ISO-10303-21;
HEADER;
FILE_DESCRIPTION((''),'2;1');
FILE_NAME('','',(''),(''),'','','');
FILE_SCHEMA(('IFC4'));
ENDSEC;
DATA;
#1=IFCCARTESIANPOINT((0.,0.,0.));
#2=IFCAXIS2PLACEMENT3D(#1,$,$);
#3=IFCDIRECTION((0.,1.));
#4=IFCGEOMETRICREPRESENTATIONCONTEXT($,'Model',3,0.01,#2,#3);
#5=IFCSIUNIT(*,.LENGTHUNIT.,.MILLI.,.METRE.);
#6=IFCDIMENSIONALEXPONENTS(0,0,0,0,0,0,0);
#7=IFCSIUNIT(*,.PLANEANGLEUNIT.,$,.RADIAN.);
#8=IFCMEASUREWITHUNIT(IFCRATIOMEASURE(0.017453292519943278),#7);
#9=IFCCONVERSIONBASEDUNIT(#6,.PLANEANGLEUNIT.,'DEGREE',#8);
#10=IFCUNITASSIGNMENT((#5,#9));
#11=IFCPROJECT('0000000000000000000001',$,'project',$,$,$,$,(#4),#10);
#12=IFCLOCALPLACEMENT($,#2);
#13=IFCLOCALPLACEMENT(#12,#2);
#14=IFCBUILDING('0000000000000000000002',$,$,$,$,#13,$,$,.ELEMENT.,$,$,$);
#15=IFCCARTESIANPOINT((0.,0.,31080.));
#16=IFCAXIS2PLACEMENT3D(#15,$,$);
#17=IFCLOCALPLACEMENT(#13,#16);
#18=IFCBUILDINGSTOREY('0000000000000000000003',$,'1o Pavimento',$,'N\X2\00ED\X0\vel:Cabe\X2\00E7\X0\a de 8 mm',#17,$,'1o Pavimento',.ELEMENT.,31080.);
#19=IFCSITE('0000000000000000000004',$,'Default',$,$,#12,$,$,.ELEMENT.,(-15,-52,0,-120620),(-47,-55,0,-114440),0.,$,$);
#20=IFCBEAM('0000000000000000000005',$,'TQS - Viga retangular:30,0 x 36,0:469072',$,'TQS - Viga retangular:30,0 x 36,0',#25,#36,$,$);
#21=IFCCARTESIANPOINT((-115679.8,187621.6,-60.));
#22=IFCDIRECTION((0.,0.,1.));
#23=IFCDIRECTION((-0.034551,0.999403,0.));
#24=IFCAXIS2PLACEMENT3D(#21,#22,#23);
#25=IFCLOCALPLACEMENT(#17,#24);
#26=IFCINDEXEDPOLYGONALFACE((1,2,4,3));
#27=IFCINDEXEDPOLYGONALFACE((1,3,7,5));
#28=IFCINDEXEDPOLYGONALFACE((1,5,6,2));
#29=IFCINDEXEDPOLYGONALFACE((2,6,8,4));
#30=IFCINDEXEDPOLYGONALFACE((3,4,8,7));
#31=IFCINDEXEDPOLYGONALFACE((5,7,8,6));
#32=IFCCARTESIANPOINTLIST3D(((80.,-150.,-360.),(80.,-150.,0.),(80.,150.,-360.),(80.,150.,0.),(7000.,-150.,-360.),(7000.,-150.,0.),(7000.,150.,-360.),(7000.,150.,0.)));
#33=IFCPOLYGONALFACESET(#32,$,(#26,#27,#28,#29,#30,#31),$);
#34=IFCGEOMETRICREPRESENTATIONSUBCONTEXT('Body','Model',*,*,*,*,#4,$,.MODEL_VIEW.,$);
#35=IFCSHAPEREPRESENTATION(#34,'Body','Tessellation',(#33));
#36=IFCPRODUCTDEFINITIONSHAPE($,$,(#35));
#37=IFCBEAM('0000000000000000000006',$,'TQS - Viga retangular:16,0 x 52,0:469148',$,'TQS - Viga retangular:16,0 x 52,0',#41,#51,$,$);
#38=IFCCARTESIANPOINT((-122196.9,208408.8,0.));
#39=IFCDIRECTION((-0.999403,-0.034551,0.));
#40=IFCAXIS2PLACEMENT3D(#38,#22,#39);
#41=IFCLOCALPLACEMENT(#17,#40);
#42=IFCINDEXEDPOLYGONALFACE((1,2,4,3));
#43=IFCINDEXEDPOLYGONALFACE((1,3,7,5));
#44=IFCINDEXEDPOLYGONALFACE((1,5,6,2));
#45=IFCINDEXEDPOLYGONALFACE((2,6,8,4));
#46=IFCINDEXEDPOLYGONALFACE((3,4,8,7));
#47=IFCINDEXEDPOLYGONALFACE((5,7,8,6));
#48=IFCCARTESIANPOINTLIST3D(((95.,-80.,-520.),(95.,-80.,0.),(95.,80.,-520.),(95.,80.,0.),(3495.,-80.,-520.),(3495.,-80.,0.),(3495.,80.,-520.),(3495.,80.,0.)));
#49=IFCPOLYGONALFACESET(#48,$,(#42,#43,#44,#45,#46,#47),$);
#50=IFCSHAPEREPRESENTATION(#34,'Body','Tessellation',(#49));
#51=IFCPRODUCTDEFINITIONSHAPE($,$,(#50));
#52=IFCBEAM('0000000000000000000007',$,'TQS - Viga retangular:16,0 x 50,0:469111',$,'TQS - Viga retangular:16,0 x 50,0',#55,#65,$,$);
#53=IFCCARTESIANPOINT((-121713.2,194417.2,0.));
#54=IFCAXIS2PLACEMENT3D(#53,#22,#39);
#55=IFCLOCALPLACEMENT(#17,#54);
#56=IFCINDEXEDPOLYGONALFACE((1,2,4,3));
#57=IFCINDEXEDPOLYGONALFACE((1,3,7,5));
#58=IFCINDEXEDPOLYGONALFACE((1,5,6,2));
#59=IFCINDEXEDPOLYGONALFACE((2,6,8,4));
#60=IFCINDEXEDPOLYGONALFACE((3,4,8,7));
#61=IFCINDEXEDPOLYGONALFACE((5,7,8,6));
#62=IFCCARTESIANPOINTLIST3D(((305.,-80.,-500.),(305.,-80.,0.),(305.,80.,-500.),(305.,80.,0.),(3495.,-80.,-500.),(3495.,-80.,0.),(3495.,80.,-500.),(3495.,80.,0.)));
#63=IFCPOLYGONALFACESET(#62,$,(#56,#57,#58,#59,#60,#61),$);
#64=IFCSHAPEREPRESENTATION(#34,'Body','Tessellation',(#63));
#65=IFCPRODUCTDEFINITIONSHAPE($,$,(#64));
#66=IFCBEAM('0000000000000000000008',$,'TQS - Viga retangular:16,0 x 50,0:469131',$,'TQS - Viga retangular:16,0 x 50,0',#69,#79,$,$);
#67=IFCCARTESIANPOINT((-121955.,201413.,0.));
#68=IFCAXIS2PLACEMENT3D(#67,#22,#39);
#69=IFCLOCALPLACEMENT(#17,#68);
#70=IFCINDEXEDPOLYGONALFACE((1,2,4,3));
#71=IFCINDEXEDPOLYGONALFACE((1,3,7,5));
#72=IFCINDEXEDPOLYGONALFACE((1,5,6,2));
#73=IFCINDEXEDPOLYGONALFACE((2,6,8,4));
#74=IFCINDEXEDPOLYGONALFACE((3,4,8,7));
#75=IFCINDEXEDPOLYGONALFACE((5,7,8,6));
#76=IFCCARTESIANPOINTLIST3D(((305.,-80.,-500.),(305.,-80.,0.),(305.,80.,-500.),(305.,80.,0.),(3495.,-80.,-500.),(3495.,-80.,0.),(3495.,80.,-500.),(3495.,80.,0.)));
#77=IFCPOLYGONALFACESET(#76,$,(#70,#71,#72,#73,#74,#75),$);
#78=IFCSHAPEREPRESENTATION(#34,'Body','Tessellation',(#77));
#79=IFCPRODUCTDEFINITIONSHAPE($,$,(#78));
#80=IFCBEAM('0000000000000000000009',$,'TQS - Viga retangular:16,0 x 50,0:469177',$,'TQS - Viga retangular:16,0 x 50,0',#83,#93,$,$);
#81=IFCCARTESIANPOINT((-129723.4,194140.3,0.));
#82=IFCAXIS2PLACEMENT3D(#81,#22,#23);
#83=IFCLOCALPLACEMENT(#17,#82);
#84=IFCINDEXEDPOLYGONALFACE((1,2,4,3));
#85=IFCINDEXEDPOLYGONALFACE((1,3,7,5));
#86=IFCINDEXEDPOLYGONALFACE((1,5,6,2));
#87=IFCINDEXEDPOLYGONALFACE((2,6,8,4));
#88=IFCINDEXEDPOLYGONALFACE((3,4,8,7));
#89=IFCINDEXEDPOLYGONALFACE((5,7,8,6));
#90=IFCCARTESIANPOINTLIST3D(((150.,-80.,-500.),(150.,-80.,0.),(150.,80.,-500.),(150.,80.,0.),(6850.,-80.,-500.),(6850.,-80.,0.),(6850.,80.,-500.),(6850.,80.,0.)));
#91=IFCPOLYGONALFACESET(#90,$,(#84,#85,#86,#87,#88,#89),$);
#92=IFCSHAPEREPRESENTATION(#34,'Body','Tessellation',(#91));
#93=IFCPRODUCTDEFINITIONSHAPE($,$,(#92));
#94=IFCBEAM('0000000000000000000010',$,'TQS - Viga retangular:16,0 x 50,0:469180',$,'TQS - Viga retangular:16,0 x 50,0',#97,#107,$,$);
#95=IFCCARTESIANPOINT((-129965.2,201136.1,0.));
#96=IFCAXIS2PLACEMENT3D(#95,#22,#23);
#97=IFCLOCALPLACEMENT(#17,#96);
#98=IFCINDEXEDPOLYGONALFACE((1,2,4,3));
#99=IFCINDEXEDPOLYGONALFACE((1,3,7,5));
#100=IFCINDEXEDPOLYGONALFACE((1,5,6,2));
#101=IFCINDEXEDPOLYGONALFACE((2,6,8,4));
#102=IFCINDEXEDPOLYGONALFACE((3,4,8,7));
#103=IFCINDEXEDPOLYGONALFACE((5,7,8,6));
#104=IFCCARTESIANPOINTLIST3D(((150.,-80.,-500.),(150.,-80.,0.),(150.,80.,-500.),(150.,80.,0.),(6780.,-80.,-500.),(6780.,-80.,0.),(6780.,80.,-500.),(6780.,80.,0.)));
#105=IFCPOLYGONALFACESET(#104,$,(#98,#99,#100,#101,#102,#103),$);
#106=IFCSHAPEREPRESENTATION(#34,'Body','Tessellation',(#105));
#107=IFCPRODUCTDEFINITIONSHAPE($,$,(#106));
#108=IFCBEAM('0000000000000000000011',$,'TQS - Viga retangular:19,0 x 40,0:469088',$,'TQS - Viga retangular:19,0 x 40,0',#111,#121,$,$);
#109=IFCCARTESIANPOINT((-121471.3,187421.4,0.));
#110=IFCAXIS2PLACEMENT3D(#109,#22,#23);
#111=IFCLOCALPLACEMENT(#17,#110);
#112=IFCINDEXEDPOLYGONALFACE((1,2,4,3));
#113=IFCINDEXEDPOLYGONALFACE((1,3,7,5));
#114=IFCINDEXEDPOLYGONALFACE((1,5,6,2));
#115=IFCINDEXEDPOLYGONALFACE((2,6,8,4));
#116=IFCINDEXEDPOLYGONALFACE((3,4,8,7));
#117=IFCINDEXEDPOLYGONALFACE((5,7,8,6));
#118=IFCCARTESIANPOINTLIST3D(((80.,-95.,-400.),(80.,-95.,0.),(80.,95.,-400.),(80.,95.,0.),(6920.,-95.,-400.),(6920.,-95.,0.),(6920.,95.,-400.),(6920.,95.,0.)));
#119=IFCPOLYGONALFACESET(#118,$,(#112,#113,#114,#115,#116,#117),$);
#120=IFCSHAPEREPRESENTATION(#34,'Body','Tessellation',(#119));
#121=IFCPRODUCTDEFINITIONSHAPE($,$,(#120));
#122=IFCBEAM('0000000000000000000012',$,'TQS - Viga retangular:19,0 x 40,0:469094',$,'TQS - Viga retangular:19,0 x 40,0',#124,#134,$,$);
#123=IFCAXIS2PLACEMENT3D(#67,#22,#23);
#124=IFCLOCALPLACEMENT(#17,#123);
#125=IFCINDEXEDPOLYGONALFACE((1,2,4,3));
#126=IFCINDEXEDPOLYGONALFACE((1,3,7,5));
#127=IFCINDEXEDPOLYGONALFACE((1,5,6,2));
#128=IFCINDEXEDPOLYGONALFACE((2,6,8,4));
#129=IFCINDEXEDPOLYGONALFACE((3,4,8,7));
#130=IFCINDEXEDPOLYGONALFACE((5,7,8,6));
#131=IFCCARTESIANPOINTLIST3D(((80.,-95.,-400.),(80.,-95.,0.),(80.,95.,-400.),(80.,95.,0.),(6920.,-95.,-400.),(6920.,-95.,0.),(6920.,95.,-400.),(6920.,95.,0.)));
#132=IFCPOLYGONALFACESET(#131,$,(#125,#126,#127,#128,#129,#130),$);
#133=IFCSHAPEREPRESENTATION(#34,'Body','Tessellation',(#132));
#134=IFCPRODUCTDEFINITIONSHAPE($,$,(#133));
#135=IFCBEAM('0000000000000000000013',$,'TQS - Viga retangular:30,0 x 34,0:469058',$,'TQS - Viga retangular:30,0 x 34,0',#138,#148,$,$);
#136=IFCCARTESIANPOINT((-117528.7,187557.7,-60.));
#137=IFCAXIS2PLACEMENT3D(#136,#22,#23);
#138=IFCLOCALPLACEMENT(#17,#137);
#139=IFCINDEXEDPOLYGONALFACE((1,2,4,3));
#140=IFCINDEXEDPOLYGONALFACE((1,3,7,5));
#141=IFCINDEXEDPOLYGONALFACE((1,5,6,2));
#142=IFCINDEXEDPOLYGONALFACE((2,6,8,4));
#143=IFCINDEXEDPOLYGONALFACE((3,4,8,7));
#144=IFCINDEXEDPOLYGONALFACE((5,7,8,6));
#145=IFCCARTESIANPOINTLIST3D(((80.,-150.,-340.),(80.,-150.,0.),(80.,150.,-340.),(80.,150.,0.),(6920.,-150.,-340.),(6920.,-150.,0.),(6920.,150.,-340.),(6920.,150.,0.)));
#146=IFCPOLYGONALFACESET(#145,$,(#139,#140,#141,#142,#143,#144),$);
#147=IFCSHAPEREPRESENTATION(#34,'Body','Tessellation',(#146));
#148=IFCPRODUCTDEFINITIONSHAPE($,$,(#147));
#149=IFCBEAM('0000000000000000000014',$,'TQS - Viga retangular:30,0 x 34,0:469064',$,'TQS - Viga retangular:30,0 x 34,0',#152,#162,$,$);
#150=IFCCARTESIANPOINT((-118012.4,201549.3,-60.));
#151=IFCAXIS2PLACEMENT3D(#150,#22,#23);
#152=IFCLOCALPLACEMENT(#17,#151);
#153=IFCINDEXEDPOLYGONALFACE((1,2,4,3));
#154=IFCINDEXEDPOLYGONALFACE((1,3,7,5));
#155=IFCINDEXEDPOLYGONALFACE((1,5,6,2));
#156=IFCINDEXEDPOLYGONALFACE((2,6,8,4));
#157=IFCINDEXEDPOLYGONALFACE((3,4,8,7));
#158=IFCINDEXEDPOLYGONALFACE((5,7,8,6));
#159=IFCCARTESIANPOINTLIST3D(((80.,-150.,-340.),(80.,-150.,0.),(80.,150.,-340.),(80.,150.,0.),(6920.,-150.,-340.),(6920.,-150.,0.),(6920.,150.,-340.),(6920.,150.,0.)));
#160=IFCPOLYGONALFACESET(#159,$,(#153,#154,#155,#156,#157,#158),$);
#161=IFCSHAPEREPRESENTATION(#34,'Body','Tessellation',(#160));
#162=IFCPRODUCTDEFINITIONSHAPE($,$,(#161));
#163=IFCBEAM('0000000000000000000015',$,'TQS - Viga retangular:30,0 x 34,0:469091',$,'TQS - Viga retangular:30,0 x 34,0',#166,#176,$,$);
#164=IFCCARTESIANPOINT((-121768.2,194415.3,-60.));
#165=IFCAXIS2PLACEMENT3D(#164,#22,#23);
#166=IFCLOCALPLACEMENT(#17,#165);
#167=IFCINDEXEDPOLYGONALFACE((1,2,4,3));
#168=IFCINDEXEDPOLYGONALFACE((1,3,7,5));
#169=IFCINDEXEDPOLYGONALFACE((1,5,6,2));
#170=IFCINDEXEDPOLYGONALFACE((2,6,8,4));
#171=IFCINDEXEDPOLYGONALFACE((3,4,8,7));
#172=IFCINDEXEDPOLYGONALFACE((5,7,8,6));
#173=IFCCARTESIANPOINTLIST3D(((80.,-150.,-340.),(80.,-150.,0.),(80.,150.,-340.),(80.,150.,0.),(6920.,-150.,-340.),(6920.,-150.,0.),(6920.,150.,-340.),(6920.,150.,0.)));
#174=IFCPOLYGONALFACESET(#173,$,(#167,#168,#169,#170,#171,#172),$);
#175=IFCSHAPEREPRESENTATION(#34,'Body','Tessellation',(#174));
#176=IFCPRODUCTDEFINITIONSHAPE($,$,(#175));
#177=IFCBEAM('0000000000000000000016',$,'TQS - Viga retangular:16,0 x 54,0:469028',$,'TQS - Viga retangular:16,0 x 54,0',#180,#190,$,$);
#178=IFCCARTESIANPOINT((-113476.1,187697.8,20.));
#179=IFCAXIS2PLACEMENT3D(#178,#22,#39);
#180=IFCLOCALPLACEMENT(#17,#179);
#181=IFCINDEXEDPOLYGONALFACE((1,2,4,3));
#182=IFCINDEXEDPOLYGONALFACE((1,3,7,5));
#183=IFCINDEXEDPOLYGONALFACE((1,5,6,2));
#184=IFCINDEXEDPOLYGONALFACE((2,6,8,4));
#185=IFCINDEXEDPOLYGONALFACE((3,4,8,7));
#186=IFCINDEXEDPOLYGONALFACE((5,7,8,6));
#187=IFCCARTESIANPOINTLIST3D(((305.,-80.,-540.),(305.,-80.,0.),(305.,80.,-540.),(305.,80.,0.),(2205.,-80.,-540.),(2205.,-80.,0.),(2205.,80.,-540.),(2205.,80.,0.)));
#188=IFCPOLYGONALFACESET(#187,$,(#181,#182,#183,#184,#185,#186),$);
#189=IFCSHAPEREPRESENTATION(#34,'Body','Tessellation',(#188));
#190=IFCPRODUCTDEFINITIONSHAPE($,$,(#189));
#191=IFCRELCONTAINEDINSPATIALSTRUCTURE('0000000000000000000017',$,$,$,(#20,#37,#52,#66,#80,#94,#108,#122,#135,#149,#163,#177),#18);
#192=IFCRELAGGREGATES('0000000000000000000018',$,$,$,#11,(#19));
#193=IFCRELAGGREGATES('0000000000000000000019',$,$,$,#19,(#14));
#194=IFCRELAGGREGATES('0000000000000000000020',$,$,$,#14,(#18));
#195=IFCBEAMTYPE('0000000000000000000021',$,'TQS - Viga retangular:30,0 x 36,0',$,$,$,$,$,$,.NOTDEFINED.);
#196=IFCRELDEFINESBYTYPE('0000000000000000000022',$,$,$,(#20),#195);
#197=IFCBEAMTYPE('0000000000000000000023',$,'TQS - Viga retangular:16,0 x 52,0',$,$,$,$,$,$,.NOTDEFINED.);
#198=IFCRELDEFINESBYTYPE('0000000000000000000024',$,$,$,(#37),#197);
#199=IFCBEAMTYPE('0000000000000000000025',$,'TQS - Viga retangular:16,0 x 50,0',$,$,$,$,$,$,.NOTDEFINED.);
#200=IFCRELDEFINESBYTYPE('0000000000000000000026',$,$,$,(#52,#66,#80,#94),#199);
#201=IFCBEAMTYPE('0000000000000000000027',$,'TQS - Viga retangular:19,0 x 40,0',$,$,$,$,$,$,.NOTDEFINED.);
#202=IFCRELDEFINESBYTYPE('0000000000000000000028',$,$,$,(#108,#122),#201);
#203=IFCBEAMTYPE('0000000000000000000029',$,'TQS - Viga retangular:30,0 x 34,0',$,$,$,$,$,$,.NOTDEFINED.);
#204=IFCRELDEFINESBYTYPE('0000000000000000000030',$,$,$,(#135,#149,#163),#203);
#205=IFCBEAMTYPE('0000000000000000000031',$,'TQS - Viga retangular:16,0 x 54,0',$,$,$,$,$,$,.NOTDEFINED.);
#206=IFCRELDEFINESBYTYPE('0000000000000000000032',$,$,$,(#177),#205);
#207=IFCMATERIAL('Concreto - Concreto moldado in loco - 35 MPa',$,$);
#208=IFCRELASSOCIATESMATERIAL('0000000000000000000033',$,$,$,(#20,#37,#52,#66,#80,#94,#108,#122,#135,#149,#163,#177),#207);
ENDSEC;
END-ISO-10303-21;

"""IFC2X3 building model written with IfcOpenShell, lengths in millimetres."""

from ifc_helpers import new_model, entity, si_unit, converted_unit, direction, frame, frame_2d, origin, place, context, subcontext, project, spatial, rectangle, extrude, material, type_object, element, save


model = new_model("IFC2X3")

# Units and contexts
model_context = context("Model", 3, precision=0.01, world=origin(), true_north=direction((0.0, 1.0)))
body_context = subcontext(model_context, "Body", "Model", "MODEL_VIEW")
ifc_project = project(units=[si_unit("LENGTHUNIT", "METRE", prefix="MILLI"), converted_unit("PLANEANGLEUNIT", "DEGREE", entity("IfcRatioMeasure", 0.017453292519943278), si_unit("PLANEANGLEUNIT", "RADIAN"), dimensions=[0, 0, 0, 0, 0, 0, 0])], contexts=[model_context])

# Site, building, storey
site_placement = place(None, origin())
site = spatial("IfcSite", under=ifc_project, at=site_placement, Name="Default", CompositionType="ELEMENT", RefLatitude=(-15, -52, 0, -120620), RefLongitude=(-47, -55, 0, -114440), RefElevation=0.0)
building_placement = place(site_placement, origin())
building = spatial("IfcBuilding", under=site, at=building_placement, CompositionType="ELEMENT")
storey_placement = place(building_placement, frame((0.0, 0.0, 31080.0)))
storey = spatial("IfcBuildingStorey", under=building, at=storey_placement, Name="1o Pavimento", ObjectType="Nível:Cabeça de 8 mm", LongName="1o Pavimento", CompositionType="ELEMENT", Elevation=31080.0)

# Beams
ifc_material_1 = material(Name="Concreto - Concreto moldado in loco - 35 MPa")
beam_type_1 = type_object("IfcBeamType", Name="TQS - Viga retangular:30,0 x 36,0", PredefinedType="NOTDEFINED")
beam_1_placement = place(storey_placement, frame((-115679.8, 187621.6, -60.0), z_axis=(0.0, 0.0, 1.0), x_axis=(-0.034551, 0.999403, 0.0)))
element("IfcBeam", 1, at=beam_1_placement, inside=storey, type_object=beam_type_1, material=ifc_material_1, Name="TQS - Viga retangular:30,0 x 36,0:469072", ObjectType="TQS - Viga retangular:30,0 x 36,0", context=body_context, shape_type="SweptSolid", body=[
    extrude(rectangle(XDim=360.0, YDim=300.0, at=frame_2d((0.0, 0.0), x_axis=(1.0, 0.0))), frame((80.0, 0.0, -180.0), z_axis=(1.0, 0.0, 0.0), x_axis=(0.0, 0.0, -1.0)), (0.0, 0.0, 1.0), 6920.0),
])
beam_type_2 = type_object("IfcBeamType", Name="TQS - Viga retangular:16,0 x 52,0", PredefinedType="NOTDEFINED")
beam_2_placement = place(storey_placement, frame((-122196.9, 208408.8, 0.0), z_axis=(0.0, 0.0, 1.0), x_axis=(-0.999403, -0.034551, 0.0)))
element("IfcBeam", 2, at=beam_2_placement, inside=storey, type_object=beam_type_2, material=ifc_material_1, Name="TQS - Viga retangular:16,0 x 52,0:469148", ObjectType="TQS - Viga retangular:16,0 x 52,0", context=body_context, shape_type="SweptSolid", body=[
    extrude(rectangle(XDim=520.0, YDim=160.0, at=frame_2d((0.0, 0.0), x_axis=(1.0, 0.0))), frame((95.0, 0.0, -260.0), z_axis=(1.0, 0.0, 0.0), x_axis=(0.0, 0.0, -1.0)), (0.0, 0.0, 1.0), 3400.0),
])
beam_type_3 = type_object("IfcBeamType", Name="TQS - Viga retangular:16,0 x 50,0", PredefinedType="NOTDEFINED")
beam_3_placement = place(storey_placement, frame((-121713.2, 194417.2, 0.0), z_axis=(0.0, 0.0, 1.0), x_axis=(-0.999403, -0.034551, 0.0)))
element("IfcBeam", 3, at=beam_3_placement, inside=storey, type_object=beam_type_3, material=ifc_material_1, Name="TQS - Viga retangular:16,0 x 50,0:469111", ObjectType="TQS - Viga retangular:16,0 x 50,0", context=body_context, shape_type="SweptSolid", body=[
    extrude(rectangle(XDim=500.0, YDim=160.0, at=frame_2d((0.0, 0.0), x_axis=(1.0, 0.0))), frame((305.0, 0.0, -250.0), z_axis=(1.0, 0.0, 0.0), x_axis=(0.0, 0.0, -1.0)), (0.0, 0.0, 1.0), 3190.0),
])
beam_4_placement = place(storey_placement, frame((-121955.0, 201413.0, 0.0), z_axis=(0.0, 0.0, 1.0), x_axis=(-0.999403, -0.034551, 0.0)))
element("IfcBeam", 4, at=beam_4_placement, inside=storey, type_object=beam_type_3, material=ifc_material_1, Name="TQS - Viga retangular:16,0 x 50,0:469131", ObjectType="TQS - Viga retangular:16,0 x 50,0", context=body_context, shape_type="SweptSolid", body=[
    extrude(rectangle(XDim=500.0, YDim=160.0, at=frame_2d((0.0, 0.0), x_axis=(1.0, 0.0))), frame((305.0, 0.0, -250.0), z_axis=(1.0, 0.0, 0.0), x_axis=(0.0, 0.0, -1.0)), (0.0, 0.0, 1.0), 3190.0),
])
beam_5_placement = place(storey_placement, frame((-129723.4, 194140.3, 0.0), z_axis=(0.0, 0.0, 1.0), x_axis=(-0.034551, 0.999403, 0.0)))
element("IfcBeam", 5, at=beam_5_placement, inside=storey, type_object=beam_type_3, material=ifc_material_1, Name="TQS - Viga retangular:16,0 x 50,0:469177", ObjectType="TQS - Viga retangular:16,0 x 50,0", context=body_context, shape_type="SweptSolid", body=[
    extrude(rectangle(XDim=500.0, YDim=160.0, at=frame_2d((0.0, 0.0), x_axis=(1.0, 0.0))), frame((150.0, 0.0, -250.0), z_axis=(1.0, 0.0, 0.0), x_axis=(0.0, 0.0, -1.0)), (0.0, 0.0, 1.0), 6700.0),
])
beam_6_placement = place(storey_placement, frame((-129965.2, 201136.1, 0.0), z_axis=(0.0, 0.0, 1.0), x_axis=(-0.034551, 0.999403, 0.0)))
element("IfcBeam", 6, at=beam_6_placement, inside=storey, type_object=beam_type_3, material=ifc_material_1, Name="TQS - Viga retangular:16,0 x 50,0:469180", ObjectType="TQS - Viga retangular:16,0 x 50,0", context=body_context, shape_type="SweptSolid", body=[
    extrude(rectangle(XDim=500.0, YDim=160.0, at=frame_2d((0.0, 0.0), x_axis=(1.0, 0.0))), frame((150.0, 0.0, -250.0), z_axis=(1.0, 0.0, 0.0), x_axis=(0.0, 0.0, -1.0)), (0.0, 0.0, 1.0), 6630.0),
])
beam_type_4 = type_object("IfcBeamType", Name="TQS - Viga retangular:19,0 x 40,0", PredefinedType="NOTDEFINED")
beam_7_placement = place(storey_placement, frame((-121471.3, 187421.4, 0.0), z_axis=(0.0, 0.0, 1.0), x_axis=(-0.034551, 0.999403, 0.0)))
element("IfcBeam", 7, at=beam_7_placement, inside=storey, type_object=beam_type_4, material=ifc_material_1, Name="TQS - Viga retangular:19,0 x 40,0:469088", ObjectType="TQS - Viga retangular:19,0 x 40,0", context=body_context, shape_type="SweptSolid", body=[
    extrude(rectangle(XDim=400.0, YDim=190.0, at=frame_2d((0.0, 0.0), x_axis=(1.0, 0.0))), frame((80.0, 0.0, -200.0), z_axis=(1.0, 0.0, 0.0), x_axis=(0.0, 0.0, -1.0)), (0.0, 0.0, 1.0), 6840.0),
])
beam_8_placement = place(storey_placement, frame((-121955.0, 201413.0, 0.0), z_axis=(0.0, 0.0, 1.0), x_axis=(-0.034551, 0.999403, 0.0)))
element("IfcBeam", 8, at=beam_8_placement, inside=storey, type_object=beam_type_4, material=ifc_material_1, Name="TQS - Viga retangular:19,0 x 40,0:469094", ObjectType="TQS - Viga retangular:19,0 x 40,0", context=body_context, shape_type="SweptSolid", body=[
    extrude(rectangle(XDim=400.0, YDim=190.0, at=frame_2d((0.0, 0.0), x_axis=(1.0, 0.0))), frame((80.0, 0.0, -200.0), z_axis=(1.0, 0.0, 0.0), x_axis=(0.0, 0.0, -1.0)), (0.0, 0.0, 1.0), 6840.0),
])
beam_type_5 = type_object("IfcBeamType", Name="TQS - Viga retangular:30,0 x 34,0", PredefinedType="NOTDEFINED")
beam_9_placement = place(storey_placement, frame((-117528.7, 187557.7, -60.0), z_axis=(0.0, 0.0, 1.0), x_axis=(-0.034551, 0.999403, 0.0)))
element("IfcBeam", 9, at=beam_9_placement, inside=storey, type_object=beam_type_5, material=ifc_material_1, Name="TQS - Viga retangular:30,0 x 34,0:469058", ObjectType="TQS - Viga retangular:30,0 x 34,0", context=body_context, shape_type="SweptSolid", body=[
    extrude(rectangle(XDim=340.0, YDim=300.0, at=frame_2d((0.0, 0.0), x_axis=(1.0, 0.0))), frame((80.0, 0.0, -170.0), z_axis=(1.0, 0.0, 0.0), x_axis=(0.0, 0.0, -1.0)), (0.0, 0.0, 1.0), 6840.0),
])
beam_10_placement = place(storey_placement, frame((-118012.4, 201549.3, -60.0), z_axis=(0.0, 0.0, 1.0), x_axis=(-0.034551, 0.999403, 0.0)))
element("IfcBeam", 10, at=beam_10_placement, inside=storey, type_object=beam_type_5, material=ifc_material_1, Name="TQS - Viga retangular:30,0 x 34,0:469064", ObjectType="TQS - Viga retangular:30,0 x 34,0", context=body_context, shape_type="SweptSolid", body=[
    extrude(rectangle(XDim=340.0, YDim=300.0, at=frame_2d((0.0, 0.0), x_axis=(1.0, 0.0))), frame((80.0, 0.0, -170.0), z_axis=(1.0, 0.0, 0.0), x_axis=(0.0, 0.0, -1.0)), (0.0, 0.0, 1.0), 6840.0),
])
beam_11_placement = place(storey_placement, frame((-121768.2, 194415.3, -60.0), z_axis=(0.0, 0.0, 1.0), x_axis=(-0.034551, 0.999403, 0.0)))
element("IfcBeam", 11, at=beam_11_placement, inside=storey, type_object=beam_type_5, material=ifc_material_1, Name="TQS - Viga retangular:30,0 x 34,0:469091", ObjectType="TQS - Viga retangular:30,0 x 34,0", context=body_context, shape_type="SweptSolid", body=[
    extrude(rectangle(XDim=340.0, YDim=300.0, at=frame_2d((0.0, 0.0), x_axis=(1.0, 0.0))), frame((80.0, 0.0, -170.0), z_axis=(1.0, 0.0, 0.0), x_axis=(0.0, 0.0, -1.0)), (0.0, 0.0, 1.0), 6840.0),
])
beam_type_6 = type_object("IfcBeamType", Name="TQS - Viga retangular:16,0 x 54,0", PredefinedType="NOTDEFINED")
beam_12_placement = place(storey_placement, frame((-113476.1, 187697.8, 20.0), z_axis=(0.0, 0.0, 1.0), x_axis=(-0.999403, -0.034551, 0.0)))
element("IfcBeam", 12, at=beam_12_placement, inside=storey, type_object=beam_type_6, material=ifc_material_1, Name="TQS - Viga retangular:16,0 x 54,0:469028", ObjectType="TQS - Viga retangular:16,0 x 54,0", context=body_context, shape_type="SweptSolid", body=[
    extrude(rectangle(XDim=540.0, YDim=160.0, at=frame_2d((0.0, 0.0), x_axis=(1.0, 0.0))), frame((305.0, 0.0, -270.0), z_axis=(1.0, 0.0, 0.0), x_axis=(0.0, 0.0, -1.0)), (0.0, 0.0, 1.0), 1900.0),
])

save(model, "model.ifc")
